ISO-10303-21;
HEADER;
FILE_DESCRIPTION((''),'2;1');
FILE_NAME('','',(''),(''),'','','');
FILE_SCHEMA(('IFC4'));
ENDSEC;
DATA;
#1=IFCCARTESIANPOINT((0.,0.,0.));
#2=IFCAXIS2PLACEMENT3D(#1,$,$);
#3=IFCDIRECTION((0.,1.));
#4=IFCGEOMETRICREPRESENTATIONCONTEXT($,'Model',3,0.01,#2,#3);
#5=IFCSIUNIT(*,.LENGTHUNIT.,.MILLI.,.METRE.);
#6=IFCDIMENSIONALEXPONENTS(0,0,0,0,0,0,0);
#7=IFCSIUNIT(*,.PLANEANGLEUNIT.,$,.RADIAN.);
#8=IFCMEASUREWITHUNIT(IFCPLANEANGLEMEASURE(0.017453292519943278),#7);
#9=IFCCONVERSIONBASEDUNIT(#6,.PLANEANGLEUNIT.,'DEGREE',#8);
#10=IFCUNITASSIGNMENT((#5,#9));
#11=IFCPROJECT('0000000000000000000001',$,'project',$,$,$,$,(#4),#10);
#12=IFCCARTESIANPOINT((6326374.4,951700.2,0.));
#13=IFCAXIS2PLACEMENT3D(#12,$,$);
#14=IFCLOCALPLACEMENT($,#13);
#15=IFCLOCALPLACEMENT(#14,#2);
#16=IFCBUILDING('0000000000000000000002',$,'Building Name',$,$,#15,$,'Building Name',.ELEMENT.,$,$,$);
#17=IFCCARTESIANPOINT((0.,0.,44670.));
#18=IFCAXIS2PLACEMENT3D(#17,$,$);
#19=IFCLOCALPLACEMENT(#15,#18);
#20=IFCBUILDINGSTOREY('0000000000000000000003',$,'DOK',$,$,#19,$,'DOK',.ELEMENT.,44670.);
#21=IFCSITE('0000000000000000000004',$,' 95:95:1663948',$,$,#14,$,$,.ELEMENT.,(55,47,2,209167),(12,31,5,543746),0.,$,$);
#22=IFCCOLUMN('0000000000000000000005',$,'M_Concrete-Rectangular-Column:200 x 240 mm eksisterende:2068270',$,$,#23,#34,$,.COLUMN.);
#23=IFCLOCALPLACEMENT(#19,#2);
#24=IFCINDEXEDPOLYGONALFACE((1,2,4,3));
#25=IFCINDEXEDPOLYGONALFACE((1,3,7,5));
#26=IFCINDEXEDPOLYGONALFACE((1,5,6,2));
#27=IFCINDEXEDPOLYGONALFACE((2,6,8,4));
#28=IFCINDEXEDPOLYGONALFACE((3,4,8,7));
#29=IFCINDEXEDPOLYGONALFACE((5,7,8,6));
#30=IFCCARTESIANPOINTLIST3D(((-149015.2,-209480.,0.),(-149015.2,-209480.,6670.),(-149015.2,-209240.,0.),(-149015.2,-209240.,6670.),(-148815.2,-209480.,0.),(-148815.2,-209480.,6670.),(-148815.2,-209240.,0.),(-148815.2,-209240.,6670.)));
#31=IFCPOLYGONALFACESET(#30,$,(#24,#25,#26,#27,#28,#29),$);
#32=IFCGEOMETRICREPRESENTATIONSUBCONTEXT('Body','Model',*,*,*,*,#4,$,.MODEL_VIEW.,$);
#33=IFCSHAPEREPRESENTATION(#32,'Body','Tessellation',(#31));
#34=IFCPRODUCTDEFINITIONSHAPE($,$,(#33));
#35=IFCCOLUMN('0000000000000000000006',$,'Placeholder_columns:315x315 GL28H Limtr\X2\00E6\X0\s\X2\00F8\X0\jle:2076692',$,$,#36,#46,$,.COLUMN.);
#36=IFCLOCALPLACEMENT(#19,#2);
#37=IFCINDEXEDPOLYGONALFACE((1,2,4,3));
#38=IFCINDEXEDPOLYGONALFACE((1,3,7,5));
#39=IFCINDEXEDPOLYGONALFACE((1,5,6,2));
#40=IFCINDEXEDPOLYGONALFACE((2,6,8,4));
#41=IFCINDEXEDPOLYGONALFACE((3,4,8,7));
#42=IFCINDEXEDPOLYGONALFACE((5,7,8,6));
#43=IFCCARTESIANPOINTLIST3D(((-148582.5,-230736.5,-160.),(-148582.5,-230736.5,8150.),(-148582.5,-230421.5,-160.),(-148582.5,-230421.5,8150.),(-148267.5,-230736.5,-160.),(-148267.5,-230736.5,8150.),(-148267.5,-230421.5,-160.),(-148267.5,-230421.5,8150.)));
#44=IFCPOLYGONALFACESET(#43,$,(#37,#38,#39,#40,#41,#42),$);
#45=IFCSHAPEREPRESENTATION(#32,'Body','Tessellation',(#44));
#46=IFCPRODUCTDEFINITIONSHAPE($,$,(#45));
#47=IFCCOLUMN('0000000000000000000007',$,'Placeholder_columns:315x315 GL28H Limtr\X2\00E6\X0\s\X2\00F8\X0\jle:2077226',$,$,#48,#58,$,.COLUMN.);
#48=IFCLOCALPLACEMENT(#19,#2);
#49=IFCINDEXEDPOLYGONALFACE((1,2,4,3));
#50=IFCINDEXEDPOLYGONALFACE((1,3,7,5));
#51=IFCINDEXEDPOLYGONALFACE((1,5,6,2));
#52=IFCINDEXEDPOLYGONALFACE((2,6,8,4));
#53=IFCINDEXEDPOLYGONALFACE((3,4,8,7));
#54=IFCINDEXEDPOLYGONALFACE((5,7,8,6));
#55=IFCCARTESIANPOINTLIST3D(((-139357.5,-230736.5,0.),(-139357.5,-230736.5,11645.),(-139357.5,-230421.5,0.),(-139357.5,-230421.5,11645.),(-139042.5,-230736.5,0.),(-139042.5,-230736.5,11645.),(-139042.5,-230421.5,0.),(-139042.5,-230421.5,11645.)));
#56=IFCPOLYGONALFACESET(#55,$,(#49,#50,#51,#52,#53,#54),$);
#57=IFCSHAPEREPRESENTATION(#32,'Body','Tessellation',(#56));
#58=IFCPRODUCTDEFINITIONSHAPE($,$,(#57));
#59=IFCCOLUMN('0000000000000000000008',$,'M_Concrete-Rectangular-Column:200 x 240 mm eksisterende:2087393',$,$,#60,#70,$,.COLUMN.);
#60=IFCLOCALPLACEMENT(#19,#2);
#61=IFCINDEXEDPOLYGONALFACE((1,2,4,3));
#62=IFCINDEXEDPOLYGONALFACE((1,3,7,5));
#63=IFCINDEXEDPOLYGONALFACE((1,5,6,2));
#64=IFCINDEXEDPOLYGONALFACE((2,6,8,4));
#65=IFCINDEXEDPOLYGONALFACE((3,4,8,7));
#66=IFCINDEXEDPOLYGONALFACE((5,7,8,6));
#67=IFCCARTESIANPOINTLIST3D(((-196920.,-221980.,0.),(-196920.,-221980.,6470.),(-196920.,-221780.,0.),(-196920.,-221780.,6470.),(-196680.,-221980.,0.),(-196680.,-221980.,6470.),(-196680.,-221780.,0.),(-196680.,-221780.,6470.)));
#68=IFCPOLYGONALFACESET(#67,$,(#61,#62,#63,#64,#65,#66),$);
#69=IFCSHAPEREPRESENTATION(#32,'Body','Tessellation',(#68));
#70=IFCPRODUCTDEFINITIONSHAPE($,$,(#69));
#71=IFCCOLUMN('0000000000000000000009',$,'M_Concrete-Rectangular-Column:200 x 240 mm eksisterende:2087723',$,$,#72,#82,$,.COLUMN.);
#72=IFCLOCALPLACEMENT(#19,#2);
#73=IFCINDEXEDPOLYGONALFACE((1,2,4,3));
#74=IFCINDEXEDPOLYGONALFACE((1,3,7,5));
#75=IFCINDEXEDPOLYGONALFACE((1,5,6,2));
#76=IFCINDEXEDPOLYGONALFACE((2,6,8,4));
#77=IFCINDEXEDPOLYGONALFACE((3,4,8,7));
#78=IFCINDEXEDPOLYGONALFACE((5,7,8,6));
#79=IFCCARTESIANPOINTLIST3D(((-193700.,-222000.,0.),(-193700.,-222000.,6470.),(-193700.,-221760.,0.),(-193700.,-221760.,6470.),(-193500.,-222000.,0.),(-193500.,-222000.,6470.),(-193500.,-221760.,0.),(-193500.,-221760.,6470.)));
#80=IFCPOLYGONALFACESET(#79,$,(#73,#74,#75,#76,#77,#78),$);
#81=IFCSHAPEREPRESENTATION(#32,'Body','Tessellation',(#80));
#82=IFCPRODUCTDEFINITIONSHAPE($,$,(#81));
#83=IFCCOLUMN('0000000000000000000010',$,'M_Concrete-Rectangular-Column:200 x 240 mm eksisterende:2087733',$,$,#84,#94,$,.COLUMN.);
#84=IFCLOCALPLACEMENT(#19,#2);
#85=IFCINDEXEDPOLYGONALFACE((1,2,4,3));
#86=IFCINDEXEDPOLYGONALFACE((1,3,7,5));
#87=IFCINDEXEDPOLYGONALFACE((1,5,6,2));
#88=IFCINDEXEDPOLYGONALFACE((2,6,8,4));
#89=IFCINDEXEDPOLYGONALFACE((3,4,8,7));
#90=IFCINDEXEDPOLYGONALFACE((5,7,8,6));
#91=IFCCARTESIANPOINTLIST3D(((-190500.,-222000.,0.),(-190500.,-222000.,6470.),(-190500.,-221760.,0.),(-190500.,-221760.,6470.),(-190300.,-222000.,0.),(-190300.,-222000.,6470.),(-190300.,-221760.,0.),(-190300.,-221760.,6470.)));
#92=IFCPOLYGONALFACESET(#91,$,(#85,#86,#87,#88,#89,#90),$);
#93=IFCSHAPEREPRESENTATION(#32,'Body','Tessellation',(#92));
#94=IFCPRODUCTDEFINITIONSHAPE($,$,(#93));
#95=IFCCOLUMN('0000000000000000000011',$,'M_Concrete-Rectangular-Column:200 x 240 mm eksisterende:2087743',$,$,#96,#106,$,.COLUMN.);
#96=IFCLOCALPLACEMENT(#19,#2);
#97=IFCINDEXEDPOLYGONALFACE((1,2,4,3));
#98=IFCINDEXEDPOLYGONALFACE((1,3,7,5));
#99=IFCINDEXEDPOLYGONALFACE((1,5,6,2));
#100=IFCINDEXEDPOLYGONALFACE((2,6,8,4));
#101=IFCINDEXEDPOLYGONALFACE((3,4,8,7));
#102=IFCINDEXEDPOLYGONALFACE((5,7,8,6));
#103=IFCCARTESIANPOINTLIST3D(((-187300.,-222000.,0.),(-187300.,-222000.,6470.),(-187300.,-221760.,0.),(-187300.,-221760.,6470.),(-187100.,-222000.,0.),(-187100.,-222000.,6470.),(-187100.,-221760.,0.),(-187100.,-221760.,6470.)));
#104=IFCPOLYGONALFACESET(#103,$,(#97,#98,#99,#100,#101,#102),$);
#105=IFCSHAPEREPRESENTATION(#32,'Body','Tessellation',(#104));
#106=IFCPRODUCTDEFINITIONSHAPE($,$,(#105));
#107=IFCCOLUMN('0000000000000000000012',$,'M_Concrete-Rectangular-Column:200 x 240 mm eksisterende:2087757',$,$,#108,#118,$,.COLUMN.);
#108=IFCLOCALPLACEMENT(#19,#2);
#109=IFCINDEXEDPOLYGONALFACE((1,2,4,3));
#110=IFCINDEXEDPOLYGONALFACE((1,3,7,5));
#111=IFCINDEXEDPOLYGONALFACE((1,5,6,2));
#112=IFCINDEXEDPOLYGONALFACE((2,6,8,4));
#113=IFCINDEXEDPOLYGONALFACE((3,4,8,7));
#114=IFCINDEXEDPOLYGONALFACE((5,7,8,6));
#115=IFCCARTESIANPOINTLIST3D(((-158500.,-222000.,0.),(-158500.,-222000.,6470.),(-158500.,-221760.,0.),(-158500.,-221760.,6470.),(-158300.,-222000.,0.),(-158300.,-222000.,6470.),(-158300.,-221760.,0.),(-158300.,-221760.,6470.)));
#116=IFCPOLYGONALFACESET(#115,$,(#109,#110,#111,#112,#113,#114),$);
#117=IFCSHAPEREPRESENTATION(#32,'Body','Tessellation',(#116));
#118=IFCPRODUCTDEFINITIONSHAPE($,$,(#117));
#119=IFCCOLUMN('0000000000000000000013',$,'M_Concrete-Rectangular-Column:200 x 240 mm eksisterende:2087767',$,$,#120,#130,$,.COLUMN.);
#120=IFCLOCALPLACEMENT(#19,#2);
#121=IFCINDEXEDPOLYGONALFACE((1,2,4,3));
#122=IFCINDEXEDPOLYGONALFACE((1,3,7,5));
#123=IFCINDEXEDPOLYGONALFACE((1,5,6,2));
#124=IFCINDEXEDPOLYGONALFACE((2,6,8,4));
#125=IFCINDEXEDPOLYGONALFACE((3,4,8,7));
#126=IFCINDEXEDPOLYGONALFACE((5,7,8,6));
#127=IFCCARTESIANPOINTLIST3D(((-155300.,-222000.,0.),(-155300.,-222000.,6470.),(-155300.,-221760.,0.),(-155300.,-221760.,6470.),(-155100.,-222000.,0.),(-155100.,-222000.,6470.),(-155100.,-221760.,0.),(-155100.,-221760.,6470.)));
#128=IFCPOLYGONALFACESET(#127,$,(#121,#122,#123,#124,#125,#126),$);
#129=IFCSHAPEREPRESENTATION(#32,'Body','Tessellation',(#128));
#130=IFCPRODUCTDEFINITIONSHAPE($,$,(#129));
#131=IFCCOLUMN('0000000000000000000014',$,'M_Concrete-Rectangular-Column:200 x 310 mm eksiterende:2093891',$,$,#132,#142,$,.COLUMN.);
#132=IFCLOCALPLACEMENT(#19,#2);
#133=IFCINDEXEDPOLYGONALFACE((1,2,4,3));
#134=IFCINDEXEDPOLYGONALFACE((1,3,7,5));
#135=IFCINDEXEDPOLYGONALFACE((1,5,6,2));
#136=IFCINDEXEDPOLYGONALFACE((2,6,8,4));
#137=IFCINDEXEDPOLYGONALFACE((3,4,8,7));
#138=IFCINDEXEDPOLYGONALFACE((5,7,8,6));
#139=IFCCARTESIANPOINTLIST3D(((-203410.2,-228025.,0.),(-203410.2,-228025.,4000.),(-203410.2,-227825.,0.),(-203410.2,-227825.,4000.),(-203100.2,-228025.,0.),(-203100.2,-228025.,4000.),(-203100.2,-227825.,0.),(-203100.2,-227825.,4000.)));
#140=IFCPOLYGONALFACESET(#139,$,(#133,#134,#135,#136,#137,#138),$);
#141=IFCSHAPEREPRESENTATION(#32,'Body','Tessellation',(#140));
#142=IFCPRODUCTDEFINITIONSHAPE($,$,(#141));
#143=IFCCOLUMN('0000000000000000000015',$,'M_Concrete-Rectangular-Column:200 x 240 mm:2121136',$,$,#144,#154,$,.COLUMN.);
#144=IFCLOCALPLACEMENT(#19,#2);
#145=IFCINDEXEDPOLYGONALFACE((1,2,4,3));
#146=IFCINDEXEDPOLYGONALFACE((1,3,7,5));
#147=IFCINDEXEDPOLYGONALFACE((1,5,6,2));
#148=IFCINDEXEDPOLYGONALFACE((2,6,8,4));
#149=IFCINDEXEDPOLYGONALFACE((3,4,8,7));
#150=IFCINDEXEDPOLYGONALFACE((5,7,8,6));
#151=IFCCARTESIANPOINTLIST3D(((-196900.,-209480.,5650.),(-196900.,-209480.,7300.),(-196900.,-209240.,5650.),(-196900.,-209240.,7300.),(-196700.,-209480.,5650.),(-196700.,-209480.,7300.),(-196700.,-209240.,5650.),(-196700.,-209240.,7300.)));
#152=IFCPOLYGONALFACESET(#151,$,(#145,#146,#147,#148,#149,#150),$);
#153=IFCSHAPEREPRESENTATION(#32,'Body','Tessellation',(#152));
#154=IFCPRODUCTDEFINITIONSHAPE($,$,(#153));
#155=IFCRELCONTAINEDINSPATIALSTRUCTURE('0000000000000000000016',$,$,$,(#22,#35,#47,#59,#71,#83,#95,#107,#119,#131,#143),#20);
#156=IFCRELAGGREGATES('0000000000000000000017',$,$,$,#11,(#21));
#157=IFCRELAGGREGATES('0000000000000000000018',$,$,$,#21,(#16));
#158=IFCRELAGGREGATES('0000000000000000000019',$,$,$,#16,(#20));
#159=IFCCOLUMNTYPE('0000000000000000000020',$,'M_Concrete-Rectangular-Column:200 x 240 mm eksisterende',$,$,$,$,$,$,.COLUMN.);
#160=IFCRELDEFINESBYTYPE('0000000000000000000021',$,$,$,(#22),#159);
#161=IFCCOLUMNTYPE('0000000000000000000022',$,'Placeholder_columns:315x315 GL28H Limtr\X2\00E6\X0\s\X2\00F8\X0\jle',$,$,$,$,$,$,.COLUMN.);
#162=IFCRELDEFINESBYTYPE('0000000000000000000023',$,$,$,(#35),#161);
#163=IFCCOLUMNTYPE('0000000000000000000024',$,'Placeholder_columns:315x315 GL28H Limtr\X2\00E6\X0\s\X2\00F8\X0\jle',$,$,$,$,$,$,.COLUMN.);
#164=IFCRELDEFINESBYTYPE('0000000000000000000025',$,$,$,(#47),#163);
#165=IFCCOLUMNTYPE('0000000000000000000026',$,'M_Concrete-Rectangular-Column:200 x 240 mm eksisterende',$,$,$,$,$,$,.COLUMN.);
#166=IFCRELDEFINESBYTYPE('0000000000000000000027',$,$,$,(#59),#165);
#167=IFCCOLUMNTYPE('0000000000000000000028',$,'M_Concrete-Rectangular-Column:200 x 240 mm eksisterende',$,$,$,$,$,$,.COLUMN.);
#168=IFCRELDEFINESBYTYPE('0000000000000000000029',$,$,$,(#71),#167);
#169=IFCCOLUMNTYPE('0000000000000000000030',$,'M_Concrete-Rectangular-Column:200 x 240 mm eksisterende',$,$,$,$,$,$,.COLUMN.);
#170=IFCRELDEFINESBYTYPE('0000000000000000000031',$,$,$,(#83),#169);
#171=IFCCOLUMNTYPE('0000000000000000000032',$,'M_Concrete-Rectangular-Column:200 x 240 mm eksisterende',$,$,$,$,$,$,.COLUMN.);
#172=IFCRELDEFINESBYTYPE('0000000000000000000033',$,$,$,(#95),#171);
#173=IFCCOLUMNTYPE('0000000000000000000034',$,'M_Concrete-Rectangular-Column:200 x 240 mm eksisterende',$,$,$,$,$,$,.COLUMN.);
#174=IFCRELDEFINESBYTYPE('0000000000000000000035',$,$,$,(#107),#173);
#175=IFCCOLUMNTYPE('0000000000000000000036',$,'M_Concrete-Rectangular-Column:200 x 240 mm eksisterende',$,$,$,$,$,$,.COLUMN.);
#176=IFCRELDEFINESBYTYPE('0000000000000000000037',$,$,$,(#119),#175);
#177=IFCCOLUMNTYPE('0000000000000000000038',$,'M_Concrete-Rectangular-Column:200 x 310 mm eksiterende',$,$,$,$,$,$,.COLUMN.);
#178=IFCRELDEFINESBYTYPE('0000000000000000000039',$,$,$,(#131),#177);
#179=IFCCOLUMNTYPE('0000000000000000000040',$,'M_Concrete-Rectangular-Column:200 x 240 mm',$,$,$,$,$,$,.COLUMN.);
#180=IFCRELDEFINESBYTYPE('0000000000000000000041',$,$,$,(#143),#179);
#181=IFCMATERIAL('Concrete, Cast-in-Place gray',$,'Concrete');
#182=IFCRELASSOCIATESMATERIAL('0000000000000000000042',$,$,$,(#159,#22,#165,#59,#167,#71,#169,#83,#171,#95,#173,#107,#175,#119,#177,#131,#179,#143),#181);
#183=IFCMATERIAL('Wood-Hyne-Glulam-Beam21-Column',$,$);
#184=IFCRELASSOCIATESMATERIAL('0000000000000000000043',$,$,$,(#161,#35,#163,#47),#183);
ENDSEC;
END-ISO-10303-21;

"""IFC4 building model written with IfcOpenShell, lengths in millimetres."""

from ifc_helpers import new_model, entity, si_unit, converted_unit, direction, frame, origin, place, context, subcontext, project, spatial, indexed_curve, outline, extrude, source, transform, mapped, material, type_object, type_shapes, element, save


model = new_model("IFC4")

# Units and contexts
model_context = context("Model", 3, precision=0.01, world=origin(), true_north=direction((0.0, 1.0)))
body_context = subcontext(model_context, "Body", "Model", "MODEL_VIEW")
ifc_project = project(units=[si_unit("LENGTHUNIT", "METRE", prefix="MILLI"), converted_unit("PLANEANGLEUNIT", "DEGREE", entity("IfcPlaneAngleMeasure", 0.017453292519943278), si_unit("PLANEANGLEUNIT", "RADIAN"), dimensions=[0, 0, 0, 0, 0, 0, 0])], contexts=[model_context])

# Site, building, storey
site_placement = place(None, frame((6326374.4, 951700.2, 0.0)))
site = spatial("IfcSite", under=ifc_project, at=site_placement, Name=" 95:95:1663948", CompositionType="ELEMENT", RefLatitude=(55, 47, 2, 209167), RefLongitude=(12, 31, 5, 543746), RefElevation=0.0)
building_placement = place(site_placement, origin())
building = spatial("IfcBuilding", under=site, at=building_placement, Name="Building Name", LongName="Building Name", CompositionType="ELEMENT")
storey_placement = place(building_placement, frame((0.0, 0.0, 44670.0)))
storey = spatial("IfcBuildingStorey", under=building, at=storey_placement, Name="DOK", LongName="DOK", CompositionType="ELEMENT", Elevation=44670.0)

# Columns
ifc_material_1 = material(Name="Concrete, Cast-in-Place gray", Category="Concrete")
column_type_1 = type_object("IfcColumnType", Name="M_Concrete-Rectangular-Column:200 x 240 mm eksisterende", PredefinedType="COLUMN", material=ifc_material_1)
shared_shape_1 = source(origin(), body_context, "Body", "SweptSolid", [
    extrude(outline(indexed_curve([(-100.0, -120.0), (100.0, -120.0), (100.0, 120.0), (-100.0, 120.0), (-100.0, -120.0)], self_intersect=False)), frame((-148915.2, -209360.0, 44670.0), z_axis=(0.0, 0.0, 1.0), x_axis=(-1.0, 0.0, 0.0)), (0.0, 0.0, 1.0), 6670.0),
])
type_shapes(column_type_1, [shared_shape_1])
column_1_placement = place(storey_placement, frame((0.0, 0.0, -44670.0)))
element("IfcColumn", 1, at=column_1_placement, inside=storey, type_object=column_type_1, material=ifc_material_1, Name="M_Concrete-Rectangular-Column:200 x 240 mm eksisterende:2068270", PredefinedType="COLUMN", context=body_context, shape_type="MappedRepresentation", body=[
    mapped(shared_shape_1, transform((0.0, 0.0, 0.0), scale=1.0)),
])
ifc_material_2 = material(Name="Wood-Hyne-Glulam-Beam21-Column")
column_type_2 = type_object("IfcColumnType", Name="Placeholder_columns:315x315 GL28H Limtræsøjle", PredefinedType="COLUMN", material=ifc_material_2)
shared_shape_2 = source(origin(), body_context, "Body", "SweptSolid", [
    extrude(outline(indexed_curve([(-157.5, -157.5), (157.5, -157.5), (157.5, 157.5), (-157.5, 157.5), (-157.5, -157.5)], self_intersect=False)), frame((-148425.0, -230579.0, 44510.0), z_axis=(0.0, 0.0, 1.0), x_axis=(-1.0, 0.0, 0.0)), (0.0, 0.0, 1.0), 8310.0),
])
type_shapes(column_type_2, [shared_shape_2])
column_2_placement = place(storey_placement, frame((0.0, 0.0, -44670.0)))
element("IfcColumn", 2, at=column_2_placement, inside=storey, type_object=column_type_2, material=ifc_material_2, Name="Placeholder_columns:315x315 GL28H Limtræsøjle:2076692", PredefinedType="COLUMN", context=body_context, shape_type="MappedRepresentation", body=[
    mapped(shared_shape_2, transform((0.0, 0.0, 0.0), scale=1.0)),
])
column_type_3 = type_object("IfcColumnType", Name="Placeholder_columns:315x315 GL28H Limtræsøjle", PredefinedType="COLUMN", material=ifc_material_2)
shared_shape_3 = source(origin(), body_context, "Body", "SweptSolid", [
    extrude(outline(indexed_curve([(-157.5, -157.5), (157.5, -157.5), (157.5, 157.5), (-157.5, 157.5), (-157.5, -157.5)], self_intersect=False)), frame((-139200.0, -230579.0, 44670.0), z_axis=(0.0, 0.0, 1.0), x_axis=(-1.0, 0.0, 0.0)), (0.0, 0.0, 1.0), 11645.0),
])
type_shapes(column_type_3, [shared_shape_3])
column_3_placement = place(storey_placement, frame((0.0, 0.0, -44670.0)))
element("IfcColumn", 3, at=column_3_placement, inside=storey, type_object=column_type_3, material=ifc_material_2, Name="Placeholder_columns:315x315 GL28H Limtræsøjle:2077226", PredefinedType="COLUMN", context=body_context, shape_type="MappedRepresentation", body=[
    mapped(shared_shape_3, transform((0.0, 0.0, 0.0), scale=1.0)),
])
column_type_4 = type_object("IfcColumnType", Name="M_Concrete-Rectangular-Column:200 x 240 mm eksisterende", PredefinedType="COLUMN", material=ifc_material_1)
shared_shape_4 = source(origin(), body_context, "Body", "SweptSolid", [
    extrude(outline(indexed_curve([(-100.0, -120.0), (100.0, -120.0), (100.0, 120.0), (-100.0, 120.0), (-100.0, -120.0)], self_intersect=False)), frame((-196800.0, -221880.0, 44670.0), z_axis=(0.0, 0.0, 1.0), x_axis=(0.0, -1.0, 0.0)), (0.0, 0.0, 1.0), 6470.0),
])
type_shapes(column_type_4, [shared_shape_4])
column_4_placement = place(storey_placement, frame((0.0, 0.0, -44670.0)))
element("IfcColumn", 4, at=column_4_placement, inside=storey, type_object=column_type_4, material=ifc_material_1, Name="M_Concrete-Rectangular-Column:200 x 240 mm eksisterende:2087393", PredefinedType="COLUMN", context=body_context, shape_type="MappedRepresentation", body=[
    mapped(shared_shape_4, transform((0.0, 0.0, 0.0), scale=1.0)),
])
column_type_5 = type_object("IfcColumnType", Name="M_Concrete-Rectangular-Column:200 x 240 mm eksisterende", PredefinedType="COLUMN", material=ifc_material_1)
shared_shape_5 = source(origin(), body_context, "Body", "SweptSolid", [
    extrude(outline(indexed_curve([(-100.0, -120.0), (100.0, -120.0), (100.0, 120.0), (-100.0, 120.0), (-100.0, -120.0)], self_intersect=False)), frame((-193600.0, -221880.0, 44670.0), z_axis=(0.0, 0.0, 1.0), x_axis=(-1.0, 0.0, 0.0)), (0.0, 0.0, 1.0), 6470.0),
])
type_shapes(column_type_5, [shared_shape_5])
column_5_placement = place(storey_placement, frame((0.0, 0.0, -44670.0)))
element("IfcColumn", 5, at=column_5_placement, inside=storey, type_object=column_type_5, material=ifc_material_1, Name="M_Concrete-Rectangular-Column:200 x 240 mm eksisterende:2087723", PredefinedType="COLUMN", context=body_context, shape_type="MappedRepresentation", body=[
    mapped(shared_shape_5, transform((0.0, 0.0, 0.0), scale=1.0)),
])
column_type_6 = type_object("IfcColumnType", Name="M_Concrete-Rectangular-Column:200 x 240 mm eksisterende", PredefinedType="COLUMN", material=ifc_material_1)
shared_shape_6 = source(origin(), body_context, "Body", "SweptSolid", [
    extrude(outline(indexed_curve([(-100.0, -120.0), (100.0, -120.0), (100.0, 120.0), (-100.0, 120.0), (-100.0, -120.0)], self_intersect=False)), frame((-190400.0, -221880.0, 44670.0), z_axis=(0.0, 0.0, 1.0), x_axis=(-1.0, 0.0, 0.0)), (0.0, 0.0, 1.0), 6470.0),
])
type_shapes(column_type_6, [shared_shape_6])
column_6_placement = place(storey_placement, frame((0.0, 0.0, -44670.0)))
element("IfcColumn", 6, at=column_6_placement, inside=storey, type_object=column_type_6, material=ifc_material_1, Name="M_Concrete-Rectangular-Column:200 x 240 mm eksisterende:2087733", PredefinedType="COLUMN", context=body_context, shape_type="MappedRepresentation", body=[
    mapped(shared_shape_6, transform((0.0, 0.0, 0.0), scale=1.0)),
])
column_type_7 = type_object("IfcColumnType", Name="M_Concrete-Rectangular-Column:200 x 240 mm eksisterende", PredefinedType="COLUMN", material=ifc_material_1)
shared_shape_7 = source(origin(), body_context, "Body", "SweptSolid", [
    extrude(outline(indexed_curve([(-100.0, -120.0), (100.0, -120.0), (100.0, 120.0), (-100.0, 120.0), (-100.0, -120.0)], self_intersect=False)), frame((-187200.0, -221880.0, 44670.0), z_axis=(0.0, 0.0, 1.0), x_axis=(-1.0, 0.0, 0.0)), (0.0, 0.0, 1.0), 6470.0),
])
type_shapes(column_type_7, [shared_shape_7])
column_7_placement = place(storey_placement, frame((0.0, 0.0, -44670.0)))
element("IfcColumn", 7, at=column_7_placement, inside=storey, type_object=column_type_7, material=ifc_material_1, Name="M_Concrete-Rectangular-Column:200 x 240 mm eksisterende:2087743", PredefinedType="COLUMN", context=body_context, shape_type="MappedRepresentation", body=[
    mapped(shared_shape_7, transform((0.0, 0.0, 0.0), scale=1.0)),
])
column_type_8 = type_object("IfcColumnType", Name="M_Concrete-Rectangular-Column:200 x 240 mm eksisterende", PredefinedType="COLUMN", material=ifc_material_1)
shared_shape_8 = source(origin(), body_context, "Body", "SweptSolid", [
    extrude(outline(indexed_curve([(-100.0, -120.0), (100.0, -120.0), (100.0, 120.0), (-100.0, 120.0), (-100.0, -120.0)], self_intersect=False)), frame((-158400.0, -221880.0, 44670.0), z_axis=(0.0, 0.0, 1.0), x_axis=(-1.0, 0.0, 0.0)), (0.0, 0.0, 1.0), 6470.0),
])
type_shapes(column_type_8, [shared_shape_8])
column_8_placement = place(storey_placement, frame((0.0, 0.0, -44670.0)))
element("IfcColumn", 8, at=column_8_placement, inside=storey, type_object=column_type_8, material=ifc_material_1, Name="M_Concrete-Rectangular-Column:200 x 240 mm eksisterende:2087757", PredefinedType="COLUMN", context=body_context, shape_type="MappedRepresentation", body=[
    mapped(shared_shape_8, transform((0.0, 0.0, 0.0), scale=1.0)),
])
column_type_9 = type_object("IfcColumnType", Name="M_Concrete-Rectangular-Column:200 x 240 mm eksisterende", PredefinedType="COLUMN", material=ifc_material_1)
shared_shape_9 = source(origin(), body_context, "Body", "SweptSolid", [
    extrude(outline(indexed_curve([(-100.0, -120.0), (100.0, -120.0), (100.0, 120.0), (-100.0, 120.0), (-100.0, -120.0)], self_intersect=False)), frame((-155200.0, -221880.0, 44670.0), z_axis=(0.0, 0.0, 1.0), x_axis=(-1.0, 0.0, 0.0)), (0.0, 0.0, 1.0), 6470.0),
])
type_shapes(column_type_9, [shared_shape_9])
column_9_placement = place(storey_placement, frame((0.0, 0.0, -44670.0)))
element("IfcColumn", 9, at=column_9_placement, inside=storey, type_object=column_type_9, material=ifc_material_1, Name="M_Concrete-Rectangular-Column:200 x 240 mm eksisterende:2087767", PredefinedType="COLUMN", context=body_context, shape_type="MappedRepresentation", body=[
    mapped(shared_shape_9, transform((0.0, 0.0, 0.0), scale=1.0)),
])
column_type_10 = type_object("IfcColumnType", Name="M_Concrete-Rectangular-Column:200 x 310 mm eksiterende", PredefinedType="COLUMN", material=ifc_material_1)
shared_shape_10 = source(origin(), body_context, "Body", "SweptSolid", [
    extrude(outline(indexed_curve([(-155.0, -100.0), (155.0, -100.0), (155.0, 100.0), (-155.0, 100.0), (-155.0, -100.0)], self_intersect=False)), frame((-203255.2, -227925.0, 44670.0), z_axis=(0.0, 0.0, 1.0), x_axis=(-1.0, 0.0, 0.0)), (0.0, 0.0, 1.0), 4000.0),
])
type_shapes(column_type_10, [shared_shape_10])
column_10_placement = place(storey_placement, frame((0.0, 0.0, -44670.0)))
element("IfcColumn", 10, at=column_10_placement, inside=storey, type_object=column_type_10, material=ifc_material_1, Name="M_Concrete-Rectangular-Column:200 x 310 mm eksiterende:2093891", PredefinedType="COLUMN", context=body_context, shape_type="MappedRepresentation", body=[
    mapped(shared_shape_10, transform((0.0, 0.0, 0.0), scale=1.0)),
])
column_type_11 = type_object("IfcColumnType", Name="M_Concrete-Rectangular-Column:200 x 240 mm", PredefinedType="COLUMN", material=ifc_material_1)
shared_shape_11 = source(origin(), body_context, "Body", "SweptSolid", [
    extrude(outline(indexed_curve([(-100.0, -120.0), (100.0, -120.0), (100.0, 120.0), (-100.0, 120.0), (-100.0, -120.0)], self_intersect=False)), frame((-196800.0, -209360.0, 50320.0), z_axis=(0.0, 0.0, 1.0), x_axis=(-1.0, 0.0, 0.0)), (0.0, 0.0, 1.0), 1650.0),
])
type_shapes(column_type_11, [shared_shape_11])
column_11_placement = place(storey_placement, frame((0.0, 0.0, -44670.0)))
element("IfcColumn", 11, at=column_11_placement, inside=storey, type_object=column_type_11, material=ifc_material_1, Name="M_Concrete-Rectangular-Column:200 x 240 mm:2121136", PredefinedType="COLUMN", context=body_context, shape_type="MappedRepresentation", body=[
    mapped(shared_shape_11, transform((0.0, 0.0, 0.0), scale=1.0)),
])

save(model, "model.ifc")
